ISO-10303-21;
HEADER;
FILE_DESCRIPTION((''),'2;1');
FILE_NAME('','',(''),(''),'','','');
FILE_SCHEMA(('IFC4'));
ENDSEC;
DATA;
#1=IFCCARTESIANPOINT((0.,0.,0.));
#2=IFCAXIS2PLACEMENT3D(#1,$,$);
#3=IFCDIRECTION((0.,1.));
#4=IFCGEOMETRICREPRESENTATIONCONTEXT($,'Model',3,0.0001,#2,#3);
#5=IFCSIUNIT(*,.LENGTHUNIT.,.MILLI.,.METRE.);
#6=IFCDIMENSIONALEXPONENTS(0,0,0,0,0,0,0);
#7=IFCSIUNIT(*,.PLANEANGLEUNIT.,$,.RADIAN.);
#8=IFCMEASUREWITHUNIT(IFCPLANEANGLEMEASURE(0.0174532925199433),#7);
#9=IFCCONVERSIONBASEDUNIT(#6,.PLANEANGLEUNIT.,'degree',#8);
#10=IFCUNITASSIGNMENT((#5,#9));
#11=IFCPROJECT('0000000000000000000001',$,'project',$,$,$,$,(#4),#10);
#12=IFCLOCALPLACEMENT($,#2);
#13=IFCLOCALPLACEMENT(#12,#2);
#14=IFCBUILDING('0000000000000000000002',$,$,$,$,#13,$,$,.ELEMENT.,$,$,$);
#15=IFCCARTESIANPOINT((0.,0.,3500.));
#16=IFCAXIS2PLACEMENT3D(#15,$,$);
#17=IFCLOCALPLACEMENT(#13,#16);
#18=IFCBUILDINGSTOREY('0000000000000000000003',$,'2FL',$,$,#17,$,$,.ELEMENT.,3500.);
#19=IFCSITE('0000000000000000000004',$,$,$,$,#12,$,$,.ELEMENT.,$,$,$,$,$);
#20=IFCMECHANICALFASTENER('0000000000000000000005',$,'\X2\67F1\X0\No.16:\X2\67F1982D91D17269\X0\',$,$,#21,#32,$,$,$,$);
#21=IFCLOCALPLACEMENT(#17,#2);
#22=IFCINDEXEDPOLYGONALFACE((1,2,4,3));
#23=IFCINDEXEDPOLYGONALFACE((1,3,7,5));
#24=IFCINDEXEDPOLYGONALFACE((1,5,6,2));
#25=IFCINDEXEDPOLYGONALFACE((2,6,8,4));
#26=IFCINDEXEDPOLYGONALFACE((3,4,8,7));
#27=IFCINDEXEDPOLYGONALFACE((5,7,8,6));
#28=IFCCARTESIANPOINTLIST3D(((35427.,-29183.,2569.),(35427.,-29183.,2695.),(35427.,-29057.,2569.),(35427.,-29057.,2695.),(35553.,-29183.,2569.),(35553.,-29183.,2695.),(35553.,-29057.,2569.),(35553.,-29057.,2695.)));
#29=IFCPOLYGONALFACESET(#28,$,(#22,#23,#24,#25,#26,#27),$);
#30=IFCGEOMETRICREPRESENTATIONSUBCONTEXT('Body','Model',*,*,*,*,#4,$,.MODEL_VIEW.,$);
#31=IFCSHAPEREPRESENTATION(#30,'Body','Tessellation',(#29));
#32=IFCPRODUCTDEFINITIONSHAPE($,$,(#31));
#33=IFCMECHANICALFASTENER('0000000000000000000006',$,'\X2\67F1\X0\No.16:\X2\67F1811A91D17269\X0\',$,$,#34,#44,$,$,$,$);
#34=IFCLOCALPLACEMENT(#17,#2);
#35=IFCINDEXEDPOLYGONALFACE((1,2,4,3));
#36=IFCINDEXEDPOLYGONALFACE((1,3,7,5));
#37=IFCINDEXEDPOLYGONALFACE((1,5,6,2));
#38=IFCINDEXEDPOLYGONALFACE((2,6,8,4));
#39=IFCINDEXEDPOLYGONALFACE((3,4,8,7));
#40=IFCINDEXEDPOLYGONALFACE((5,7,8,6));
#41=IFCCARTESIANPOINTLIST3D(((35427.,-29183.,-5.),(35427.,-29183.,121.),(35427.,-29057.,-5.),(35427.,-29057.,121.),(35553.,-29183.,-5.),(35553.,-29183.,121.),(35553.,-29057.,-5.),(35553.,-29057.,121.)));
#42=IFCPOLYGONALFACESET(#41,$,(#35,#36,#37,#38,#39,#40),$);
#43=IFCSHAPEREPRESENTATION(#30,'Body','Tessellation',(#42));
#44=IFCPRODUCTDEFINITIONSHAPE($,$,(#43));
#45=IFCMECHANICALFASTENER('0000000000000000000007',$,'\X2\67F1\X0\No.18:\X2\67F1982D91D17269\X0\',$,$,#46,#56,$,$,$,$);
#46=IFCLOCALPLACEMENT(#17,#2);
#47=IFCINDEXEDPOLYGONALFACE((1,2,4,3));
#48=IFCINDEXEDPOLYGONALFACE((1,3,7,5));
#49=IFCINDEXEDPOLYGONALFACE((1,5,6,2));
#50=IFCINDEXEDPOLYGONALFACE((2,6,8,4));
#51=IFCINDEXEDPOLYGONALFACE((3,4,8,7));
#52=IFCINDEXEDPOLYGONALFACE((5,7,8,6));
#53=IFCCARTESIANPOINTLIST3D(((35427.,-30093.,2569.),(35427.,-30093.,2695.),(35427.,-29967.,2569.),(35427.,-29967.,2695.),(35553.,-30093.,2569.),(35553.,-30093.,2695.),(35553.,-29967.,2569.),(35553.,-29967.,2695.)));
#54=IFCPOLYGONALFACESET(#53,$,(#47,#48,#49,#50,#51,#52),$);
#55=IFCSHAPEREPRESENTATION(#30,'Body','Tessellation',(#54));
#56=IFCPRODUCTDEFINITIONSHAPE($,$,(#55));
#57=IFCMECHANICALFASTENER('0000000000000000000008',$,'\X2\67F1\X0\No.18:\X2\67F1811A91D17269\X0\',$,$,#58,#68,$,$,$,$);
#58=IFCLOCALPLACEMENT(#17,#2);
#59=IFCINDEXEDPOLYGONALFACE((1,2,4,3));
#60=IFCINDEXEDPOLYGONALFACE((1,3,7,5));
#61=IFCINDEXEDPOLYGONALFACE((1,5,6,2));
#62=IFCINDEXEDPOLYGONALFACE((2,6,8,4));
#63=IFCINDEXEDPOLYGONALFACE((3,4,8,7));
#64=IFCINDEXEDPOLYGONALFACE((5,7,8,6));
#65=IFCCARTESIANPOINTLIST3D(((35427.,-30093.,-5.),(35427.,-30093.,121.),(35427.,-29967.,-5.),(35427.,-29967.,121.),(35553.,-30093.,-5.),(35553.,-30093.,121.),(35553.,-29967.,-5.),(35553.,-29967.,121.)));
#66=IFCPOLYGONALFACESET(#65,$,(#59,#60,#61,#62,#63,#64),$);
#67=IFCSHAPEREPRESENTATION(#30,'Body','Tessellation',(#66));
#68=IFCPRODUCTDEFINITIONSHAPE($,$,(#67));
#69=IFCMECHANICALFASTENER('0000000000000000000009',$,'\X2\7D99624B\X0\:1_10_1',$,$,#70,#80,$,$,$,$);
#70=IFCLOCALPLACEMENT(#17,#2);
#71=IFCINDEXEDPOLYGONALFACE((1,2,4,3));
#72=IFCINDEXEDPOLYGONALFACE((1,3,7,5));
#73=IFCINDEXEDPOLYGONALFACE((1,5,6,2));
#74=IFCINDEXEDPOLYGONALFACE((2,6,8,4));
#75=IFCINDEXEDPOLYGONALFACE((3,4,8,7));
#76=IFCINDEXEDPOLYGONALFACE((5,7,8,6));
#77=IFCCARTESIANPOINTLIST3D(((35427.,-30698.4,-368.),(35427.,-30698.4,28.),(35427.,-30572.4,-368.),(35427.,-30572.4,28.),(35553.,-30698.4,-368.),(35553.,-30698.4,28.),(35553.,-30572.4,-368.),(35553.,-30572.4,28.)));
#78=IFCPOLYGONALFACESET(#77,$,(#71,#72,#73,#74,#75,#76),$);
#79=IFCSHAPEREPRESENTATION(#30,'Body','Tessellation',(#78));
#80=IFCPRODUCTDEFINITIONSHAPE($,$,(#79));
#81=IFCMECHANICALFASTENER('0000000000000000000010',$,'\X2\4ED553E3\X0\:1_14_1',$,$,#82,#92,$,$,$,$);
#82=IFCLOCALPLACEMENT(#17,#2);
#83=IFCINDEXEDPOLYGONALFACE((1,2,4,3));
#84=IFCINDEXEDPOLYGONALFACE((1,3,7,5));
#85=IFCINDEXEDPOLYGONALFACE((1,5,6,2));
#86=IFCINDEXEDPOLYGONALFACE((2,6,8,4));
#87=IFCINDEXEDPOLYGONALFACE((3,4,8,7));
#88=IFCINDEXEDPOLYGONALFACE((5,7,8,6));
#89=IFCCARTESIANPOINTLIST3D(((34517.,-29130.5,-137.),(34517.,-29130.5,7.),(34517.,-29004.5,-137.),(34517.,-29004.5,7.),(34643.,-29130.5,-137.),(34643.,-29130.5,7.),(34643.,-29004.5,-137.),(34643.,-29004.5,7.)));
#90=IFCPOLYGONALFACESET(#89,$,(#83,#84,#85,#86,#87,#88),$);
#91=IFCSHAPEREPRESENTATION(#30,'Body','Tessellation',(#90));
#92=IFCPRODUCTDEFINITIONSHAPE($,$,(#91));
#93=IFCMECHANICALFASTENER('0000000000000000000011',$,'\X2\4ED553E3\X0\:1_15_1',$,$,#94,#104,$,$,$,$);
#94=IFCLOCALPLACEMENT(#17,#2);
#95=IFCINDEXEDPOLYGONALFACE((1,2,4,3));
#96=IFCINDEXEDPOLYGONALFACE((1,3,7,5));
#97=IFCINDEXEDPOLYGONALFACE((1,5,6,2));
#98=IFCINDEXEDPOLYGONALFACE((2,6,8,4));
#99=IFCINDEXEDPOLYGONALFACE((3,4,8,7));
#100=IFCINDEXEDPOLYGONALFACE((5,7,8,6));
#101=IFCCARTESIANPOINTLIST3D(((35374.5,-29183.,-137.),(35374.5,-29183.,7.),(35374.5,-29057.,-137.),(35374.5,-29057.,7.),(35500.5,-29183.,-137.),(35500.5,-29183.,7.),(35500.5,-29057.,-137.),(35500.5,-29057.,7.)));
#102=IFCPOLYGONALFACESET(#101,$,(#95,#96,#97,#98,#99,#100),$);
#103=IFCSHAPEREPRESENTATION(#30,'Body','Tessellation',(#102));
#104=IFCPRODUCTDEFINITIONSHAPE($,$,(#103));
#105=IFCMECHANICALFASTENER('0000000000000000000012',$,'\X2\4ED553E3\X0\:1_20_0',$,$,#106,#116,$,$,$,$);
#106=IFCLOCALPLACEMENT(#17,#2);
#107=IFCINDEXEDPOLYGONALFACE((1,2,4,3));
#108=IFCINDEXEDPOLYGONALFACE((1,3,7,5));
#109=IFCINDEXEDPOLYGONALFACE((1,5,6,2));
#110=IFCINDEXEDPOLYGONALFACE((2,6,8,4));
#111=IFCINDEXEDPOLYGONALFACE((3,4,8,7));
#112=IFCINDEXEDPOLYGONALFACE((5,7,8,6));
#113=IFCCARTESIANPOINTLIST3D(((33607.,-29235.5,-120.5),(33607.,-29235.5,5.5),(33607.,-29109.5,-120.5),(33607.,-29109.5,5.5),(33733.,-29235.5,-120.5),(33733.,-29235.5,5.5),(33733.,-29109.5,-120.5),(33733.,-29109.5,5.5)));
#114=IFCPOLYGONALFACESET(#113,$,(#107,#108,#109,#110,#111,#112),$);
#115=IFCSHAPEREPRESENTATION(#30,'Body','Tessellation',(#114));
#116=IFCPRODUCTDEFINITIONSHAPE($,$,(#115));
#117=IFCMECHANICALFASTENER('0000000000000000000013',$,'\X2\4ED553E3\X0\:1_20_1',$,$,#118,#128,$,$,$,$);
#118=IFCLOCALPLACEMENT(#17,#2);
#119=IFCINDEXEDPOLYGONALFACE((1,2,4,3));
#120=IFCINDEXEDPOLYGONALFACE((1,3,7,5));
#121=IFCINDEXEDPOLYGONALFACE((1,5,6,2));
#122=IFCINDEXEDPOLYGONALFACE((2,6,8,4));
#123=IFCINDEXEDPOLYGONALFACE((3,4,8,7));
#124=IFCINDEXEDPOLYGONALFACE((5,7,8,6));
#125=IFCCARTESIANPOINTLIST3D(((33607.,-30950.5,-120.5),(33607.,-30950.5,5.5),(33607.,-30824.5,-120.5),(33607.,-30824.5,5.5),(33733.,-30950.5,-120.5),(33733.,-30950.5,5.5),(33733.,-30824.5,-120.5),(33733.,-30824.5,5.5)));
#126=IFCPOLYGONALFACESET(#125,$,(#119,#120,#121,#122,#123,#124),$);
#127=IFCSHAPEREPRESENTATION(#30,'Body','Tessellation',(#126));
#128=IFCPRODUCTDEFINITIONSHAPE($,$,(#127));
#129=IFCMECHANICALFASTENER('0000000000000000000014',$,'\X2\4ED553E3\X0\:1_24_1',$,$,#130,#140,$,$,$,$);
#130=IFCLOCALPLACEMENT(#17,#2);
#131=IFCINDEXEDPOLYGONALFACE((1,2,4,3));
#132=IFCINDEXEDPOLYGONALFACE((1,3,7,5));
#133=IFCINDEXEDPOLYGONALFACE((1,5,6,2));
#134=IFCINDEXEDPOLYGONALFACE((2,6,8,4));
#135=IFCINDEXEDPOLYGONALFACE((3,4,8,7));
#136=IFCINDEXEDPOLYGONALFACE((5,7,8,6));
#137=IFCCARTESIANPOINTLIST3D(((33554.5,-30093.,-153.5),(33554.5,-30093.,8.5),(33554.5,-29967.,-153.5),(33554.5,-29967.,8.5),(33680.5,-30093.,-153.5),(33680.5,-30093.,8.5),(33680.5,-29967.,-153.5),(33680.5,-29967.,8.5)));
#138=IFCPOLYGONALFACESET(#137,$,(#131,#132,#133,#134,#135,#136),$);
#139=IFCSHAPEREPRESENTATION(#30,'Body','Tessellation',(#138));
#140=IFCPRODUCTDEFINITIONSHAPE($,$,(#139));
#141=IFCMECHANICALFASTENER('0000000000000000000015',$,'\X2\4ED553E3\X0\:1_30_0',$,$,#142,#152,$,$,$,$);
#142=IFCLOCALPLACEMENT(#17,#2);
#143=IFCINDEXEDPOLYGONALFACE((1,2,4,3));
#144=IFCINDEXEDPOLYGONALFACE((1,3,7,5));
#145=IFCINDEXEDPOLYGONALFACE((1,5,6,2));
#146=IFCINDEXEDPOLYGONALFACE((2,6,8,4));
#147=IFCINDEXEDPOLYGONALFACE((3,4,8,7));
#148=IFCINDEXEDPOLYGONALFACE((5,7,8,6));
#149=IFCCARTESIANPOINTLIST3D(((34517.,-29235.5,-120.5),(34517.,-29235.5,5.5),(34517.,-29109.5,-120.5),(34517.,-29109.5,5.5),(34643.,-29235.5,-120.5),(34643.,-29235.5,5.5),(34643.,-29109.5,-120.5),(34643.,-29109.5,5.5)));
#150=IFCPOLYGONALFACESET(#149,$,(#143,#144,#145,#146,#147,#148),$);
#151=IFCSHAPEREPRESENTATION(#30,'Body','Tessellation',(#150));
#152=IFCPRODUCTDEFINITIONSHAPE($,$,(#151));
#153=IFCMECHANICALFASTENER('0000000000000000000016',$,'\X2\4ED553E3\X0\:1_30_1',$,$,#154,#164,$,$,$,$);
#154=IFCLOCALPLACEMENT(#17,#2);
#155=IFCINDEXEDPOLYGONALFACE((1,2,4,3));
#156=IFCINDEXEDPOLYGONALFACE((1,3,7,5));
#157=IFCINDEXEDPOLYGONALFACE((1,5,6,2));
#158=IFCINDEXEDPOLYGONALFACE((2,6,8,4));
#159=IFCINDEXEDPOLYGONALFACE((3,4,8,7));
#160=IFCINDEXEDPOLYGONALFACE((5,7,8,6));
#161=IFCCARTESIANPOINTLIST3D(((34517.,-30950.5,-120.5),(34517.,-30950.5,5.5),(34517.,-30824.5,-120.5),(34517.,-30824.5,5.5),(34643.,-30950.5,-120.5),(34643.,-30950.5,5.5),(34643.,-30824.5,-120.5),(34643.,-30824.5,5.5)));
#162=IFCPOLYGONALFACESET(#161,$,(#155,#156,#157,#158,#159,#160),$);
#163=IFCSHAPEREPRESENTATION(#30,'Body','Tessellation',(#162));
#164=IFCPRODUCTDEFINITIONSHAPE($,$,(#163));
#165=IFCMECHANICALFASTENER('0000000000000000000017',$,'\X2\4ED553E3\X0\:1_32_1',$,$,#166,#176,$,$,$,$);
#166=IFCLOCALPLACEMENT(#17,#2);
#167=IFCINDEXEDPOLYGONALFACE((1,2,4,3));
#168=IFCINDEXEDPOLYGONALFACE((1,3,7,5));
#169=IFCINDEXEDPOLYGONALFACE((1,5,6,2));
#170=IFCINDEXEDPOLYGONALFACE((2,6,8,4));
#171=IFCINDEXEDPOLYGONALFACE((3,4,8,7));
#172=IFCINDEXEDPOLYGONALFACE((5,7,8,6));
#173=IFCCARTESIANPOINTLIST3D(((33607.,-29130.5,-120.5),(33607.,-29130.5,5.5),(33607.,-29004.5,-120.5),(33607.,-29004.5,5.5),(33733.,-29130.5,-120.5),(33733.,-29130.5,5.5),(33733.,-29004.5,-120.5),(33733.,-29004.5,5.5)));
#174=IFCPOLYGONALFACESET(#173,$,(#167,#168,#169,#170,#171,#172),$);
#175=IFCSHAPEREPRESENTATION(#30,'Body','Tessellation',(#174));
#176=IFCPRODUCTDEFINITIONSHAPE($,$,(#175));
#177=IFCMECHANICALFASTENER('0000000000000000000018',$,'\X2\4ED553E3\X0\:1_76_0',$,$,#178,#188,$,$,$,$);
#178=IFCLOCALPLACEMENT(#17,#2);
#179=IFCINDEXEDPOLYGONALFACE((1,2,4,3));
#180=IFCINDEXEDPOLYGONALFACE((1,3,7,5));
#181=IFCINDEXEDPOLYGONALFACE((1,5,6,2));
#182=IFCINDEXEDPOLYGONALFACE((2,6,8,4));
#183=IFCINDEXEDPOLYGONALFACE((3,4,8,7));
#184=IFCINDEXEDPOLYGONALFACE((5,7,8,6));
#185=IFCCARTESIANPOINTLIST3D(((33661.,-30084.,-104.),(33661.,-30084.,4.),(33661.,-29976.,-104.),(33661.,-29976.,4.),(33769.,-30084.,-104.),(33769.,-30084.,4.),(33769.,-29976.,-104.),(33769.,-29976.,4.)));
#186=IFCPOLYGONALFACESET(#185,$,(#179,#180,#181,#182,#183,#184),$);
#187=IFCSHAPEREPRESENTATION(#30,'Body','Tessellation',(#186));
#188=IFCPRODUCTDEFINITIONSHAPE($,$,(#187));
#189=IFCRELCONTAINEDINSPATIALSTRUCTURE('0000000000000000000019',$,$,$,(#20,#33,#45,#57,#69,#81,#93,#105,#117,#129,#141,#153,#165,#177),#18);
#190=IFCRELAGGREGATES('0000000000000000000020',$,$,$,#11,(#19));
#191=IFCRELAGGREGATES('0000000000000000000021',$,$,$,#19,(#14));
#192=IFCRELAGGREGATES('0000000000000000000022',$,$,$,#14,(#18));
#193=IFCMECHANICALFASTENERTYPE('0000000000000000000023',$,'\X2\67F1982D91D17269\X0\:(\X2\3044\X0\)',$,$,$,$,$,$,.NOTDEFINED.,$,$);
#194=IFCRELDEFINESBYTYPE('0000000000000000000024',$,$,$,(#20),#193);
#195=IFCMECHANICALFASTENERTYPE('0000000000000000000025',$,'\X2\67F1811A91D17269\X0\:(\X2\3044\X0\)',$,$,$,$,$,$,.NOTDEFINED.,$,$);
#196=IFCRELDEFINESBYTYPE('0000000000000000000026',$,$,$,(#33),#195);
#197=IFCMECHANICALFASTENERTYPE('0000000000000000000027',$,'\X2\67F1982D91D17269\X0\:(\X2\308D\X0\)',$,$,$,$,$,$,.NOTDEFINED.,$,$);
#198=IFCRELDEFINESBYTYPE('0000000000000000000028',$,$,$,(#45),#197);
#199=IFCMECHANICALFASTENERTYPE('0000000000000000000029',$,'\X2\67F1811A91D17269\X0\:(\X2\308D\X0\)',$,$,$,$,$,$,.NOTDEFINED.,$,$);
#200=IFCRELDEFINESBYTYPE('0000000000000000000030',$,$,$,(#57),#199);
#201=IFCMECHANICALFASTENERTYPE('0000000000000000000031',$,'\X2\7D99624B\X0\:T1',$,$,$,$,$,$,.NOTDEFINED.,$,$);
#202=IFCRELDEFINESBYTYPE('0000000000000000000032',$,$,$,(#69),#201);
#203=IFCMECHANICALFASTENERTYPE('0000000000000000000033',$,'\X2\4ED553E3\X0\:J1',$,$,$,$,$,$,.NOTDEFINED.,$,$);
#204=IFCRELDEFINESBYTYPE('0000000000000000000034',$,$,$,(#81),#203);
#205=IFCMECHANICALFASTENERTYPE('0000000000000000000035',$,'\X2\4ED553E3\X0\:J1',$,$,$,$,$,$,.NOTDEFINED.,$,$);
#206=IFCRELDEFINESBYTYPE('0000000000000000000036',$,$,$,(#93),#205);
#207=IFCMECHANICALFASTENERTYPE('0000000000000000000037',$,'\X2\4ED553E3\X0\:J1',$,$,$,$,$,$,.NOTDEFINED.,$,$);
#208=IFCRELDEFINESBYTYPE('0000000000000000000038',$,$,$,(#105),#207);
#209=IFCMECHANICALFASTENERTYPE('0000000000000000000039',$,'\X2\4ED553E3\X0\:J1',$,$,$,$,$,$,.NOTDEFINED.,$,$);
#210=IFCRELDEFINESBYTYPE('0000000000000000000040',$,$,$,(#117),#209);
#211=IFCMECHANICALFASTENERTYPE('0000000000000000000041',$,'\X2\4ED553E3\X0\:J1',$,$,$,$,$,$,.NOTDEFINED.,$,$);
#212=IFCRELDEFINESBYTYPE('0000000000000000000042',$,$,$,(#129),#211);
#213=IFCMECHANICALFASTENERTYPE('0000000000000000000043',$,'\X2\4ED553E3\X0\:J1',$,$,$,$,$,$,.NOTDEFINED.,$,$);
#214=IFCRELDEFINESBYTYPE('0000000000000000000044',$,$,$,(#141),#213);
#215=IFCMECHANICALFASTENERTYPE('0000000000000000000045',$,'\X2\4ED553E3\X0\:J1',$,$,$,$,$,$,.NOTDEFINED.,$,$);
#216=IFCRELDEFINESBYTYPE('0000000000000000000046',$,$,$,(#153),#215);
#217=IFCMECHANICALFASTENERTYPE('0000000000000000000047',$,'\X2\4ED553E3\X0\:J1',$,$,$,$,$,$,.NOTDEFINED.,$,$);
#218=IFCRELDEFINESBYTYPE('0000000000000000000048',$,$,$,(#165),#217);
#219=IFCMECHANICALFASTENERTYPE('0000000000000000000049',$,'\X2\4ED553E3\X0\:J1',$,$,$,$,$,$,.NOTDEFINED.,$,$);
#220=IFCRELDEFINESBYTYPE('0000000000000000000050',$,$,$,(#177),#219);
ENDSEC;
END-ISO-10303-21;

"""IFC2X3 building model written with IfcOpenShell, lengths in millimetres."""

from ifc_helpers import new_model, entity, si_unit, converted_unit, direction, frame, origin, origin_with_axes, origin_2d, place, context, subcontext, project, spatial, rectangle, extrude, type_object, element, save


model = new_model("IFC2X3")

# Units and contexts
model_context = context("Model", 3, precision=0.0001, world=origin(), true_north=direction((0.0, 1.0)))
body_context = subcontext(model_context, "Body", "Model", "MODEL_VIEW")
ifc_project = project(units=[si_unit("LENGTHUNIT", "METRE", prefix="MILLI"), converted_unit("PLANEANGLEUNIT", "degree", entity("IfcPlaneAngleMeasure", 0.0174532925199433), si_unit("PLANEANGLEUNIT", "RADIAN"), dimensions=[0, 0, 0, 0, 0, 0, 0])], contexts=[model_context])

# Site, building, storey
site_placement = place(None, origin())
site = spatial("IfcSite", under=ifc_project, at=site_placement, CompositionType="ELEMENT")
building_placement = place(site_placement, origin())
building = spatial("IfcBuilding", under=site, at=building_placement, CompositionType="ELEMENT")
storey_placement = place(building_placement, frame((0.0, 0.0, 3500.0)))
storey = spatial("IfcBuildingStorey", under=building, at=storey_placement, Name="2FL", CompositionType="ELEMENT", Elevation=3500.0)

# Mechanical fasteners
mechanical_fastener_type_1 = type_object("IfcMechanicalFastenerType", Name="柱頭金物:(い)")
mechanical_fastener_1_placement = place(storey_placement, frame((35490.0, -29120.0, 2569.0)))
element("IfcMechanicalFastener", 1, at=mechanical_fastener_1_placement, inside=storey, type_object=mechanical_fastener_type_1, Name="柱No.16:柱頭金物", context=body_context, shape_type="SweptSolid", body=[
    extrude(rectangle(XDim=126.0, YDim=126.0, at=origin_2d()), origin_with_axes(), (0.0, 0.0, 1.0), 126.0),
])
mechanical_fastener_type_2 = type_object("IfcMechanicalFastenerType", Name="柱脚金物:(い)")
mechanical_fastener_2_placement = place(storey_placement, frame((35490.0, -29120.0, -5.0)))
element("IfcMechanicalFastener", 2, at=mechanical_fastener_2_placement, inside=storey, type_object=mechanical_fastener_type_2, Name="柱No.16:柱脚金物", context=body_context, shape_type="SweptSolid", body=[
    extrude(rectangle(XDim=126.0, YDim=126.0, at=origin_2d()), origin_with_axes(), (0.0, 0.0, 1.0), 126.0),
])
mechanical_fastener_type_3 = type_object("IfcMechanicalFastenerType", Name="柱頭金物:(ろ)")
mechanical_fastener_3_placement = place(storey_placement, frame((35490.0, -30030.0, 2569.0)))
element("IfcMechanicalFastener", 3, at=mechanical_fastener_3_placement, inside=storey, type_object=mechanical_fastener_type_3, Name="柱No.18:柱頭金物", context=body_context, shape_type="SweptSolid", body=[
    extrude(rectangle(XDim=126.0, YDim=126.0, at=origin_2d()), origin_with_axes(), (0.0, 0.0, 1.0), 126.0),
])
mechanical_fastener_type_4 = type_object("IfcMechanicalFastenerType", Name="柱脚金物:(ろ)")
mechanical_fastener_4_placement = place(storey_placement, frame((35490.0, -30030.0, -5.0)))
element("IfcMechanicalFastener", 4, at=mechanical_fastener_4_placement, inside=storey, type_object=mechanical_fastener_type_4, Name="柱No.18:柱脚金物", context=body_context, shape_type="SweptSolid", body=[
    extrude(rectangle(XDim=126.0, YDim=126.0, at=origin_2d()), origin_with_axes(), (0.0, 0.0, 1.0), 126.0),
])
mechanical_fastener_type_5 = type_object("IfcMechanicalFastenerType", Name="継手:T1")
mechanical_fastener_5_placement = place(storey_placement, frame((35490.0, -30635.4, -368.0)))
element("IfcMechanicalFastener", 5, at=mechanical_fastener_5_placement, inside=storey, type_object=mechanical_fastener_type_5, Name="継手:1_10_1", context=body_context, shape_type="SweptSolid", body=[
    extrude(rectangle(XDim=126.0, YDim=126.0, at=origin_2d()), origin_with_axes(), (0.0, 0.0, 1.0), 396.0),
])
mechanical_fastener_type_6 = type_object("IfcMechanicalFastenerType", Name="仕口:J1")
mechanical_fastener_6_placement = place(storey_placement, frame((34580.0, -29067.5, -137.0)))
element("IfcMechanicalFastener", 6, at=mechanical_fastener_6_placement, inside=storey, type_object=mechanical_fastener_type_6, Name="仕口:1_14_1", context=body_context, shape_type="SweptSolid", body=[
    extrude(rectangle(XDim=126.0, YDim=126.0, at=origin_2d()), origin_with_axes(), (0.0, 0.0, 1.0), 144.0),
])
mechanical_fastener_type_7 = type_object("IfcMechanicalFastenerType", Name="仕口:J1")
mechanical_fastener_7_placement = place(storey_placement, frame((35437.5, -29120.0, -137.0)))
element("IfcMechanicalFastener", 7, at=mechanical_fastener_7_placement, inside=storey, type_object=mechanical_fastener_type_7, Name="仕口:1_15_1", context=body_context, shape_type="SweptSolid", body=[
    extrude(rectangle(XDim=126.0, YDim=126.0, at=origin_2d()), origin_with_axes(), (0.0, 0.0, 1.0), 144.0),
])
mechanical_fastener_type_8 = type_object("IfcMechanicalFastenerType", Name="仕口:J1")
mechanical_fastener_8_placement = place(storey_placement, frame((33670.0, -29172.5, -120.5)))
element("IfcMechanicalFastener", 8, at=mechanical_fastener_8_placement, inside=storey, type_object=mechanical_fastener_type_8, Name="仕口:1_20_0", context=body_context, shape_type="SweptSolid", body=[
    extrude(rectangle(XDim=126.0, YDim=126.0, at=origin_2d()), origin_with_axes(), (0.0, 0.0, 1.0), 126.0),
])
mechanical_fastener_type_9 = type_object("IfcMechanicalFastenerType", Name="仕口:J1")
mechanical_fastener_9_placement = place(storey_placement, frame((33670.0, -30887.5, -120.5)))
element("IfcMechanicalFastener", 9, at=mechanical_fastener_9_placement, inside=storey, type_object=mechanical_fastener_type_9, Name="仕口:1_20_1", context=body_context, shape_type="SweptSolid", body=[
    extrude(rectangle(XDim=126.0, YDim=126.0, at=origin_2d()), origin_with_axes(), (0.0, 0.0, 1.0), 126.0),
])
mechanical_fastener_type_10 = type_object("IfcMechanicalFastenerType", Name="仕口:J1")
mechanical_fastener_10_placement = place(storey_placement, frame((33617.5, -30030.0, -153.5)))
element("IfcMechanicalFastener", 10, at=mechanical_fastener_10_placement, inside=storey, type_object=mechanical_fastener_type_10, Name="仕口:1_24_1", context=body_context, shape_type="SweptSolid", body=[
    extrude(rectangle(XDim=126.0, YDim=126.0, at=origin_2d()), origin_with_axes(), (0.0, 0.0, 1.0), 162.0),
])
mechanical_fastener_type_11 = type_object("IfcMechanicalFastenerType", Name="仕口:J1")
mechanical_fastener_11_placement = place(storey_placement, frame((34580.0, -29172.5, -120.5)))
element("IfcMechanicalFastener", 11, at=mechanical_fastener_11_placement, inside=storey, type_object=mechanical_fastener_type_11, Name="仕口:1_30_0", context=body_context, shape_type="SweptSolid", body=[
    extrude(rectangle(XDim=126.0, YDim=126.0, at=origin_2d()), origin_with_axes(), (0.0, 0.0, 1.0), 126.0),
])
mechanical_fastener_type_12 = type_object("IfcMechanicalFastenerType", Name="仕口:J1")
mechanical_fastener_12_placement = place(storey_placement, frame((34580.0, -30887.5, -120.5)))
element("IfcMechanicalFastener", 12, at=mechanical_fastener_12_placement, inside=storey, type_object=mechanical_fastener_type_12, Name="仕口:1_30_1", context=body_context, shape_type="SweptSolid", body=[
    extrude(rectangle(XDim=126.0, YDim=126.0, at=origin_2d()), origin_with_axes(), (0.0, 0.0, 1.0), 126.0),
])
mechanical_fastener_type_13 = type_object("IfcMechanicalFastenerType", Name="仕口:J1")
mechanical_fastener_13_placement = place(storey_placement, frame((33670.0, -29067.5, -120.5)))
element("IfcMechanicalFastener", 13, at=mechanical_fastener_13_placement, inside=storey, type_object=mechanical_fastener_type_13, Name="仕口:1_32_1", context=body_context, shape_type="SweptSolid", body=[
    extrude(rectangle(XDim=126.0, YDim=126.0, at=origin_2d()), origin_with_axes(), (0.0, 0.0, 1.0), 126.0),
])
mechanical_fastener_type_14 = type_object("IfcMechanicalFastenerType", Name="仕口:J1")
mechanical_fastener_14_placement = place(storey_placement, frame((33715.0, -30030.0, -104.0)))
element("IfcMechanicalFastener", 14, at=mechanical_fastener_14_placement, inside=storey, type_object=mechanical_fastener_type_14, Name="仕口:1_76_0", context=body_context, shape_type="SweptSolid", body=[
    extrude(rectangle(XDim=108.0, YDim=108.0, at=origin_2d()), origin_with_axes(), (0.0, 0.0, 1.0), 108.0),
])

save(model, "model.ifc")
